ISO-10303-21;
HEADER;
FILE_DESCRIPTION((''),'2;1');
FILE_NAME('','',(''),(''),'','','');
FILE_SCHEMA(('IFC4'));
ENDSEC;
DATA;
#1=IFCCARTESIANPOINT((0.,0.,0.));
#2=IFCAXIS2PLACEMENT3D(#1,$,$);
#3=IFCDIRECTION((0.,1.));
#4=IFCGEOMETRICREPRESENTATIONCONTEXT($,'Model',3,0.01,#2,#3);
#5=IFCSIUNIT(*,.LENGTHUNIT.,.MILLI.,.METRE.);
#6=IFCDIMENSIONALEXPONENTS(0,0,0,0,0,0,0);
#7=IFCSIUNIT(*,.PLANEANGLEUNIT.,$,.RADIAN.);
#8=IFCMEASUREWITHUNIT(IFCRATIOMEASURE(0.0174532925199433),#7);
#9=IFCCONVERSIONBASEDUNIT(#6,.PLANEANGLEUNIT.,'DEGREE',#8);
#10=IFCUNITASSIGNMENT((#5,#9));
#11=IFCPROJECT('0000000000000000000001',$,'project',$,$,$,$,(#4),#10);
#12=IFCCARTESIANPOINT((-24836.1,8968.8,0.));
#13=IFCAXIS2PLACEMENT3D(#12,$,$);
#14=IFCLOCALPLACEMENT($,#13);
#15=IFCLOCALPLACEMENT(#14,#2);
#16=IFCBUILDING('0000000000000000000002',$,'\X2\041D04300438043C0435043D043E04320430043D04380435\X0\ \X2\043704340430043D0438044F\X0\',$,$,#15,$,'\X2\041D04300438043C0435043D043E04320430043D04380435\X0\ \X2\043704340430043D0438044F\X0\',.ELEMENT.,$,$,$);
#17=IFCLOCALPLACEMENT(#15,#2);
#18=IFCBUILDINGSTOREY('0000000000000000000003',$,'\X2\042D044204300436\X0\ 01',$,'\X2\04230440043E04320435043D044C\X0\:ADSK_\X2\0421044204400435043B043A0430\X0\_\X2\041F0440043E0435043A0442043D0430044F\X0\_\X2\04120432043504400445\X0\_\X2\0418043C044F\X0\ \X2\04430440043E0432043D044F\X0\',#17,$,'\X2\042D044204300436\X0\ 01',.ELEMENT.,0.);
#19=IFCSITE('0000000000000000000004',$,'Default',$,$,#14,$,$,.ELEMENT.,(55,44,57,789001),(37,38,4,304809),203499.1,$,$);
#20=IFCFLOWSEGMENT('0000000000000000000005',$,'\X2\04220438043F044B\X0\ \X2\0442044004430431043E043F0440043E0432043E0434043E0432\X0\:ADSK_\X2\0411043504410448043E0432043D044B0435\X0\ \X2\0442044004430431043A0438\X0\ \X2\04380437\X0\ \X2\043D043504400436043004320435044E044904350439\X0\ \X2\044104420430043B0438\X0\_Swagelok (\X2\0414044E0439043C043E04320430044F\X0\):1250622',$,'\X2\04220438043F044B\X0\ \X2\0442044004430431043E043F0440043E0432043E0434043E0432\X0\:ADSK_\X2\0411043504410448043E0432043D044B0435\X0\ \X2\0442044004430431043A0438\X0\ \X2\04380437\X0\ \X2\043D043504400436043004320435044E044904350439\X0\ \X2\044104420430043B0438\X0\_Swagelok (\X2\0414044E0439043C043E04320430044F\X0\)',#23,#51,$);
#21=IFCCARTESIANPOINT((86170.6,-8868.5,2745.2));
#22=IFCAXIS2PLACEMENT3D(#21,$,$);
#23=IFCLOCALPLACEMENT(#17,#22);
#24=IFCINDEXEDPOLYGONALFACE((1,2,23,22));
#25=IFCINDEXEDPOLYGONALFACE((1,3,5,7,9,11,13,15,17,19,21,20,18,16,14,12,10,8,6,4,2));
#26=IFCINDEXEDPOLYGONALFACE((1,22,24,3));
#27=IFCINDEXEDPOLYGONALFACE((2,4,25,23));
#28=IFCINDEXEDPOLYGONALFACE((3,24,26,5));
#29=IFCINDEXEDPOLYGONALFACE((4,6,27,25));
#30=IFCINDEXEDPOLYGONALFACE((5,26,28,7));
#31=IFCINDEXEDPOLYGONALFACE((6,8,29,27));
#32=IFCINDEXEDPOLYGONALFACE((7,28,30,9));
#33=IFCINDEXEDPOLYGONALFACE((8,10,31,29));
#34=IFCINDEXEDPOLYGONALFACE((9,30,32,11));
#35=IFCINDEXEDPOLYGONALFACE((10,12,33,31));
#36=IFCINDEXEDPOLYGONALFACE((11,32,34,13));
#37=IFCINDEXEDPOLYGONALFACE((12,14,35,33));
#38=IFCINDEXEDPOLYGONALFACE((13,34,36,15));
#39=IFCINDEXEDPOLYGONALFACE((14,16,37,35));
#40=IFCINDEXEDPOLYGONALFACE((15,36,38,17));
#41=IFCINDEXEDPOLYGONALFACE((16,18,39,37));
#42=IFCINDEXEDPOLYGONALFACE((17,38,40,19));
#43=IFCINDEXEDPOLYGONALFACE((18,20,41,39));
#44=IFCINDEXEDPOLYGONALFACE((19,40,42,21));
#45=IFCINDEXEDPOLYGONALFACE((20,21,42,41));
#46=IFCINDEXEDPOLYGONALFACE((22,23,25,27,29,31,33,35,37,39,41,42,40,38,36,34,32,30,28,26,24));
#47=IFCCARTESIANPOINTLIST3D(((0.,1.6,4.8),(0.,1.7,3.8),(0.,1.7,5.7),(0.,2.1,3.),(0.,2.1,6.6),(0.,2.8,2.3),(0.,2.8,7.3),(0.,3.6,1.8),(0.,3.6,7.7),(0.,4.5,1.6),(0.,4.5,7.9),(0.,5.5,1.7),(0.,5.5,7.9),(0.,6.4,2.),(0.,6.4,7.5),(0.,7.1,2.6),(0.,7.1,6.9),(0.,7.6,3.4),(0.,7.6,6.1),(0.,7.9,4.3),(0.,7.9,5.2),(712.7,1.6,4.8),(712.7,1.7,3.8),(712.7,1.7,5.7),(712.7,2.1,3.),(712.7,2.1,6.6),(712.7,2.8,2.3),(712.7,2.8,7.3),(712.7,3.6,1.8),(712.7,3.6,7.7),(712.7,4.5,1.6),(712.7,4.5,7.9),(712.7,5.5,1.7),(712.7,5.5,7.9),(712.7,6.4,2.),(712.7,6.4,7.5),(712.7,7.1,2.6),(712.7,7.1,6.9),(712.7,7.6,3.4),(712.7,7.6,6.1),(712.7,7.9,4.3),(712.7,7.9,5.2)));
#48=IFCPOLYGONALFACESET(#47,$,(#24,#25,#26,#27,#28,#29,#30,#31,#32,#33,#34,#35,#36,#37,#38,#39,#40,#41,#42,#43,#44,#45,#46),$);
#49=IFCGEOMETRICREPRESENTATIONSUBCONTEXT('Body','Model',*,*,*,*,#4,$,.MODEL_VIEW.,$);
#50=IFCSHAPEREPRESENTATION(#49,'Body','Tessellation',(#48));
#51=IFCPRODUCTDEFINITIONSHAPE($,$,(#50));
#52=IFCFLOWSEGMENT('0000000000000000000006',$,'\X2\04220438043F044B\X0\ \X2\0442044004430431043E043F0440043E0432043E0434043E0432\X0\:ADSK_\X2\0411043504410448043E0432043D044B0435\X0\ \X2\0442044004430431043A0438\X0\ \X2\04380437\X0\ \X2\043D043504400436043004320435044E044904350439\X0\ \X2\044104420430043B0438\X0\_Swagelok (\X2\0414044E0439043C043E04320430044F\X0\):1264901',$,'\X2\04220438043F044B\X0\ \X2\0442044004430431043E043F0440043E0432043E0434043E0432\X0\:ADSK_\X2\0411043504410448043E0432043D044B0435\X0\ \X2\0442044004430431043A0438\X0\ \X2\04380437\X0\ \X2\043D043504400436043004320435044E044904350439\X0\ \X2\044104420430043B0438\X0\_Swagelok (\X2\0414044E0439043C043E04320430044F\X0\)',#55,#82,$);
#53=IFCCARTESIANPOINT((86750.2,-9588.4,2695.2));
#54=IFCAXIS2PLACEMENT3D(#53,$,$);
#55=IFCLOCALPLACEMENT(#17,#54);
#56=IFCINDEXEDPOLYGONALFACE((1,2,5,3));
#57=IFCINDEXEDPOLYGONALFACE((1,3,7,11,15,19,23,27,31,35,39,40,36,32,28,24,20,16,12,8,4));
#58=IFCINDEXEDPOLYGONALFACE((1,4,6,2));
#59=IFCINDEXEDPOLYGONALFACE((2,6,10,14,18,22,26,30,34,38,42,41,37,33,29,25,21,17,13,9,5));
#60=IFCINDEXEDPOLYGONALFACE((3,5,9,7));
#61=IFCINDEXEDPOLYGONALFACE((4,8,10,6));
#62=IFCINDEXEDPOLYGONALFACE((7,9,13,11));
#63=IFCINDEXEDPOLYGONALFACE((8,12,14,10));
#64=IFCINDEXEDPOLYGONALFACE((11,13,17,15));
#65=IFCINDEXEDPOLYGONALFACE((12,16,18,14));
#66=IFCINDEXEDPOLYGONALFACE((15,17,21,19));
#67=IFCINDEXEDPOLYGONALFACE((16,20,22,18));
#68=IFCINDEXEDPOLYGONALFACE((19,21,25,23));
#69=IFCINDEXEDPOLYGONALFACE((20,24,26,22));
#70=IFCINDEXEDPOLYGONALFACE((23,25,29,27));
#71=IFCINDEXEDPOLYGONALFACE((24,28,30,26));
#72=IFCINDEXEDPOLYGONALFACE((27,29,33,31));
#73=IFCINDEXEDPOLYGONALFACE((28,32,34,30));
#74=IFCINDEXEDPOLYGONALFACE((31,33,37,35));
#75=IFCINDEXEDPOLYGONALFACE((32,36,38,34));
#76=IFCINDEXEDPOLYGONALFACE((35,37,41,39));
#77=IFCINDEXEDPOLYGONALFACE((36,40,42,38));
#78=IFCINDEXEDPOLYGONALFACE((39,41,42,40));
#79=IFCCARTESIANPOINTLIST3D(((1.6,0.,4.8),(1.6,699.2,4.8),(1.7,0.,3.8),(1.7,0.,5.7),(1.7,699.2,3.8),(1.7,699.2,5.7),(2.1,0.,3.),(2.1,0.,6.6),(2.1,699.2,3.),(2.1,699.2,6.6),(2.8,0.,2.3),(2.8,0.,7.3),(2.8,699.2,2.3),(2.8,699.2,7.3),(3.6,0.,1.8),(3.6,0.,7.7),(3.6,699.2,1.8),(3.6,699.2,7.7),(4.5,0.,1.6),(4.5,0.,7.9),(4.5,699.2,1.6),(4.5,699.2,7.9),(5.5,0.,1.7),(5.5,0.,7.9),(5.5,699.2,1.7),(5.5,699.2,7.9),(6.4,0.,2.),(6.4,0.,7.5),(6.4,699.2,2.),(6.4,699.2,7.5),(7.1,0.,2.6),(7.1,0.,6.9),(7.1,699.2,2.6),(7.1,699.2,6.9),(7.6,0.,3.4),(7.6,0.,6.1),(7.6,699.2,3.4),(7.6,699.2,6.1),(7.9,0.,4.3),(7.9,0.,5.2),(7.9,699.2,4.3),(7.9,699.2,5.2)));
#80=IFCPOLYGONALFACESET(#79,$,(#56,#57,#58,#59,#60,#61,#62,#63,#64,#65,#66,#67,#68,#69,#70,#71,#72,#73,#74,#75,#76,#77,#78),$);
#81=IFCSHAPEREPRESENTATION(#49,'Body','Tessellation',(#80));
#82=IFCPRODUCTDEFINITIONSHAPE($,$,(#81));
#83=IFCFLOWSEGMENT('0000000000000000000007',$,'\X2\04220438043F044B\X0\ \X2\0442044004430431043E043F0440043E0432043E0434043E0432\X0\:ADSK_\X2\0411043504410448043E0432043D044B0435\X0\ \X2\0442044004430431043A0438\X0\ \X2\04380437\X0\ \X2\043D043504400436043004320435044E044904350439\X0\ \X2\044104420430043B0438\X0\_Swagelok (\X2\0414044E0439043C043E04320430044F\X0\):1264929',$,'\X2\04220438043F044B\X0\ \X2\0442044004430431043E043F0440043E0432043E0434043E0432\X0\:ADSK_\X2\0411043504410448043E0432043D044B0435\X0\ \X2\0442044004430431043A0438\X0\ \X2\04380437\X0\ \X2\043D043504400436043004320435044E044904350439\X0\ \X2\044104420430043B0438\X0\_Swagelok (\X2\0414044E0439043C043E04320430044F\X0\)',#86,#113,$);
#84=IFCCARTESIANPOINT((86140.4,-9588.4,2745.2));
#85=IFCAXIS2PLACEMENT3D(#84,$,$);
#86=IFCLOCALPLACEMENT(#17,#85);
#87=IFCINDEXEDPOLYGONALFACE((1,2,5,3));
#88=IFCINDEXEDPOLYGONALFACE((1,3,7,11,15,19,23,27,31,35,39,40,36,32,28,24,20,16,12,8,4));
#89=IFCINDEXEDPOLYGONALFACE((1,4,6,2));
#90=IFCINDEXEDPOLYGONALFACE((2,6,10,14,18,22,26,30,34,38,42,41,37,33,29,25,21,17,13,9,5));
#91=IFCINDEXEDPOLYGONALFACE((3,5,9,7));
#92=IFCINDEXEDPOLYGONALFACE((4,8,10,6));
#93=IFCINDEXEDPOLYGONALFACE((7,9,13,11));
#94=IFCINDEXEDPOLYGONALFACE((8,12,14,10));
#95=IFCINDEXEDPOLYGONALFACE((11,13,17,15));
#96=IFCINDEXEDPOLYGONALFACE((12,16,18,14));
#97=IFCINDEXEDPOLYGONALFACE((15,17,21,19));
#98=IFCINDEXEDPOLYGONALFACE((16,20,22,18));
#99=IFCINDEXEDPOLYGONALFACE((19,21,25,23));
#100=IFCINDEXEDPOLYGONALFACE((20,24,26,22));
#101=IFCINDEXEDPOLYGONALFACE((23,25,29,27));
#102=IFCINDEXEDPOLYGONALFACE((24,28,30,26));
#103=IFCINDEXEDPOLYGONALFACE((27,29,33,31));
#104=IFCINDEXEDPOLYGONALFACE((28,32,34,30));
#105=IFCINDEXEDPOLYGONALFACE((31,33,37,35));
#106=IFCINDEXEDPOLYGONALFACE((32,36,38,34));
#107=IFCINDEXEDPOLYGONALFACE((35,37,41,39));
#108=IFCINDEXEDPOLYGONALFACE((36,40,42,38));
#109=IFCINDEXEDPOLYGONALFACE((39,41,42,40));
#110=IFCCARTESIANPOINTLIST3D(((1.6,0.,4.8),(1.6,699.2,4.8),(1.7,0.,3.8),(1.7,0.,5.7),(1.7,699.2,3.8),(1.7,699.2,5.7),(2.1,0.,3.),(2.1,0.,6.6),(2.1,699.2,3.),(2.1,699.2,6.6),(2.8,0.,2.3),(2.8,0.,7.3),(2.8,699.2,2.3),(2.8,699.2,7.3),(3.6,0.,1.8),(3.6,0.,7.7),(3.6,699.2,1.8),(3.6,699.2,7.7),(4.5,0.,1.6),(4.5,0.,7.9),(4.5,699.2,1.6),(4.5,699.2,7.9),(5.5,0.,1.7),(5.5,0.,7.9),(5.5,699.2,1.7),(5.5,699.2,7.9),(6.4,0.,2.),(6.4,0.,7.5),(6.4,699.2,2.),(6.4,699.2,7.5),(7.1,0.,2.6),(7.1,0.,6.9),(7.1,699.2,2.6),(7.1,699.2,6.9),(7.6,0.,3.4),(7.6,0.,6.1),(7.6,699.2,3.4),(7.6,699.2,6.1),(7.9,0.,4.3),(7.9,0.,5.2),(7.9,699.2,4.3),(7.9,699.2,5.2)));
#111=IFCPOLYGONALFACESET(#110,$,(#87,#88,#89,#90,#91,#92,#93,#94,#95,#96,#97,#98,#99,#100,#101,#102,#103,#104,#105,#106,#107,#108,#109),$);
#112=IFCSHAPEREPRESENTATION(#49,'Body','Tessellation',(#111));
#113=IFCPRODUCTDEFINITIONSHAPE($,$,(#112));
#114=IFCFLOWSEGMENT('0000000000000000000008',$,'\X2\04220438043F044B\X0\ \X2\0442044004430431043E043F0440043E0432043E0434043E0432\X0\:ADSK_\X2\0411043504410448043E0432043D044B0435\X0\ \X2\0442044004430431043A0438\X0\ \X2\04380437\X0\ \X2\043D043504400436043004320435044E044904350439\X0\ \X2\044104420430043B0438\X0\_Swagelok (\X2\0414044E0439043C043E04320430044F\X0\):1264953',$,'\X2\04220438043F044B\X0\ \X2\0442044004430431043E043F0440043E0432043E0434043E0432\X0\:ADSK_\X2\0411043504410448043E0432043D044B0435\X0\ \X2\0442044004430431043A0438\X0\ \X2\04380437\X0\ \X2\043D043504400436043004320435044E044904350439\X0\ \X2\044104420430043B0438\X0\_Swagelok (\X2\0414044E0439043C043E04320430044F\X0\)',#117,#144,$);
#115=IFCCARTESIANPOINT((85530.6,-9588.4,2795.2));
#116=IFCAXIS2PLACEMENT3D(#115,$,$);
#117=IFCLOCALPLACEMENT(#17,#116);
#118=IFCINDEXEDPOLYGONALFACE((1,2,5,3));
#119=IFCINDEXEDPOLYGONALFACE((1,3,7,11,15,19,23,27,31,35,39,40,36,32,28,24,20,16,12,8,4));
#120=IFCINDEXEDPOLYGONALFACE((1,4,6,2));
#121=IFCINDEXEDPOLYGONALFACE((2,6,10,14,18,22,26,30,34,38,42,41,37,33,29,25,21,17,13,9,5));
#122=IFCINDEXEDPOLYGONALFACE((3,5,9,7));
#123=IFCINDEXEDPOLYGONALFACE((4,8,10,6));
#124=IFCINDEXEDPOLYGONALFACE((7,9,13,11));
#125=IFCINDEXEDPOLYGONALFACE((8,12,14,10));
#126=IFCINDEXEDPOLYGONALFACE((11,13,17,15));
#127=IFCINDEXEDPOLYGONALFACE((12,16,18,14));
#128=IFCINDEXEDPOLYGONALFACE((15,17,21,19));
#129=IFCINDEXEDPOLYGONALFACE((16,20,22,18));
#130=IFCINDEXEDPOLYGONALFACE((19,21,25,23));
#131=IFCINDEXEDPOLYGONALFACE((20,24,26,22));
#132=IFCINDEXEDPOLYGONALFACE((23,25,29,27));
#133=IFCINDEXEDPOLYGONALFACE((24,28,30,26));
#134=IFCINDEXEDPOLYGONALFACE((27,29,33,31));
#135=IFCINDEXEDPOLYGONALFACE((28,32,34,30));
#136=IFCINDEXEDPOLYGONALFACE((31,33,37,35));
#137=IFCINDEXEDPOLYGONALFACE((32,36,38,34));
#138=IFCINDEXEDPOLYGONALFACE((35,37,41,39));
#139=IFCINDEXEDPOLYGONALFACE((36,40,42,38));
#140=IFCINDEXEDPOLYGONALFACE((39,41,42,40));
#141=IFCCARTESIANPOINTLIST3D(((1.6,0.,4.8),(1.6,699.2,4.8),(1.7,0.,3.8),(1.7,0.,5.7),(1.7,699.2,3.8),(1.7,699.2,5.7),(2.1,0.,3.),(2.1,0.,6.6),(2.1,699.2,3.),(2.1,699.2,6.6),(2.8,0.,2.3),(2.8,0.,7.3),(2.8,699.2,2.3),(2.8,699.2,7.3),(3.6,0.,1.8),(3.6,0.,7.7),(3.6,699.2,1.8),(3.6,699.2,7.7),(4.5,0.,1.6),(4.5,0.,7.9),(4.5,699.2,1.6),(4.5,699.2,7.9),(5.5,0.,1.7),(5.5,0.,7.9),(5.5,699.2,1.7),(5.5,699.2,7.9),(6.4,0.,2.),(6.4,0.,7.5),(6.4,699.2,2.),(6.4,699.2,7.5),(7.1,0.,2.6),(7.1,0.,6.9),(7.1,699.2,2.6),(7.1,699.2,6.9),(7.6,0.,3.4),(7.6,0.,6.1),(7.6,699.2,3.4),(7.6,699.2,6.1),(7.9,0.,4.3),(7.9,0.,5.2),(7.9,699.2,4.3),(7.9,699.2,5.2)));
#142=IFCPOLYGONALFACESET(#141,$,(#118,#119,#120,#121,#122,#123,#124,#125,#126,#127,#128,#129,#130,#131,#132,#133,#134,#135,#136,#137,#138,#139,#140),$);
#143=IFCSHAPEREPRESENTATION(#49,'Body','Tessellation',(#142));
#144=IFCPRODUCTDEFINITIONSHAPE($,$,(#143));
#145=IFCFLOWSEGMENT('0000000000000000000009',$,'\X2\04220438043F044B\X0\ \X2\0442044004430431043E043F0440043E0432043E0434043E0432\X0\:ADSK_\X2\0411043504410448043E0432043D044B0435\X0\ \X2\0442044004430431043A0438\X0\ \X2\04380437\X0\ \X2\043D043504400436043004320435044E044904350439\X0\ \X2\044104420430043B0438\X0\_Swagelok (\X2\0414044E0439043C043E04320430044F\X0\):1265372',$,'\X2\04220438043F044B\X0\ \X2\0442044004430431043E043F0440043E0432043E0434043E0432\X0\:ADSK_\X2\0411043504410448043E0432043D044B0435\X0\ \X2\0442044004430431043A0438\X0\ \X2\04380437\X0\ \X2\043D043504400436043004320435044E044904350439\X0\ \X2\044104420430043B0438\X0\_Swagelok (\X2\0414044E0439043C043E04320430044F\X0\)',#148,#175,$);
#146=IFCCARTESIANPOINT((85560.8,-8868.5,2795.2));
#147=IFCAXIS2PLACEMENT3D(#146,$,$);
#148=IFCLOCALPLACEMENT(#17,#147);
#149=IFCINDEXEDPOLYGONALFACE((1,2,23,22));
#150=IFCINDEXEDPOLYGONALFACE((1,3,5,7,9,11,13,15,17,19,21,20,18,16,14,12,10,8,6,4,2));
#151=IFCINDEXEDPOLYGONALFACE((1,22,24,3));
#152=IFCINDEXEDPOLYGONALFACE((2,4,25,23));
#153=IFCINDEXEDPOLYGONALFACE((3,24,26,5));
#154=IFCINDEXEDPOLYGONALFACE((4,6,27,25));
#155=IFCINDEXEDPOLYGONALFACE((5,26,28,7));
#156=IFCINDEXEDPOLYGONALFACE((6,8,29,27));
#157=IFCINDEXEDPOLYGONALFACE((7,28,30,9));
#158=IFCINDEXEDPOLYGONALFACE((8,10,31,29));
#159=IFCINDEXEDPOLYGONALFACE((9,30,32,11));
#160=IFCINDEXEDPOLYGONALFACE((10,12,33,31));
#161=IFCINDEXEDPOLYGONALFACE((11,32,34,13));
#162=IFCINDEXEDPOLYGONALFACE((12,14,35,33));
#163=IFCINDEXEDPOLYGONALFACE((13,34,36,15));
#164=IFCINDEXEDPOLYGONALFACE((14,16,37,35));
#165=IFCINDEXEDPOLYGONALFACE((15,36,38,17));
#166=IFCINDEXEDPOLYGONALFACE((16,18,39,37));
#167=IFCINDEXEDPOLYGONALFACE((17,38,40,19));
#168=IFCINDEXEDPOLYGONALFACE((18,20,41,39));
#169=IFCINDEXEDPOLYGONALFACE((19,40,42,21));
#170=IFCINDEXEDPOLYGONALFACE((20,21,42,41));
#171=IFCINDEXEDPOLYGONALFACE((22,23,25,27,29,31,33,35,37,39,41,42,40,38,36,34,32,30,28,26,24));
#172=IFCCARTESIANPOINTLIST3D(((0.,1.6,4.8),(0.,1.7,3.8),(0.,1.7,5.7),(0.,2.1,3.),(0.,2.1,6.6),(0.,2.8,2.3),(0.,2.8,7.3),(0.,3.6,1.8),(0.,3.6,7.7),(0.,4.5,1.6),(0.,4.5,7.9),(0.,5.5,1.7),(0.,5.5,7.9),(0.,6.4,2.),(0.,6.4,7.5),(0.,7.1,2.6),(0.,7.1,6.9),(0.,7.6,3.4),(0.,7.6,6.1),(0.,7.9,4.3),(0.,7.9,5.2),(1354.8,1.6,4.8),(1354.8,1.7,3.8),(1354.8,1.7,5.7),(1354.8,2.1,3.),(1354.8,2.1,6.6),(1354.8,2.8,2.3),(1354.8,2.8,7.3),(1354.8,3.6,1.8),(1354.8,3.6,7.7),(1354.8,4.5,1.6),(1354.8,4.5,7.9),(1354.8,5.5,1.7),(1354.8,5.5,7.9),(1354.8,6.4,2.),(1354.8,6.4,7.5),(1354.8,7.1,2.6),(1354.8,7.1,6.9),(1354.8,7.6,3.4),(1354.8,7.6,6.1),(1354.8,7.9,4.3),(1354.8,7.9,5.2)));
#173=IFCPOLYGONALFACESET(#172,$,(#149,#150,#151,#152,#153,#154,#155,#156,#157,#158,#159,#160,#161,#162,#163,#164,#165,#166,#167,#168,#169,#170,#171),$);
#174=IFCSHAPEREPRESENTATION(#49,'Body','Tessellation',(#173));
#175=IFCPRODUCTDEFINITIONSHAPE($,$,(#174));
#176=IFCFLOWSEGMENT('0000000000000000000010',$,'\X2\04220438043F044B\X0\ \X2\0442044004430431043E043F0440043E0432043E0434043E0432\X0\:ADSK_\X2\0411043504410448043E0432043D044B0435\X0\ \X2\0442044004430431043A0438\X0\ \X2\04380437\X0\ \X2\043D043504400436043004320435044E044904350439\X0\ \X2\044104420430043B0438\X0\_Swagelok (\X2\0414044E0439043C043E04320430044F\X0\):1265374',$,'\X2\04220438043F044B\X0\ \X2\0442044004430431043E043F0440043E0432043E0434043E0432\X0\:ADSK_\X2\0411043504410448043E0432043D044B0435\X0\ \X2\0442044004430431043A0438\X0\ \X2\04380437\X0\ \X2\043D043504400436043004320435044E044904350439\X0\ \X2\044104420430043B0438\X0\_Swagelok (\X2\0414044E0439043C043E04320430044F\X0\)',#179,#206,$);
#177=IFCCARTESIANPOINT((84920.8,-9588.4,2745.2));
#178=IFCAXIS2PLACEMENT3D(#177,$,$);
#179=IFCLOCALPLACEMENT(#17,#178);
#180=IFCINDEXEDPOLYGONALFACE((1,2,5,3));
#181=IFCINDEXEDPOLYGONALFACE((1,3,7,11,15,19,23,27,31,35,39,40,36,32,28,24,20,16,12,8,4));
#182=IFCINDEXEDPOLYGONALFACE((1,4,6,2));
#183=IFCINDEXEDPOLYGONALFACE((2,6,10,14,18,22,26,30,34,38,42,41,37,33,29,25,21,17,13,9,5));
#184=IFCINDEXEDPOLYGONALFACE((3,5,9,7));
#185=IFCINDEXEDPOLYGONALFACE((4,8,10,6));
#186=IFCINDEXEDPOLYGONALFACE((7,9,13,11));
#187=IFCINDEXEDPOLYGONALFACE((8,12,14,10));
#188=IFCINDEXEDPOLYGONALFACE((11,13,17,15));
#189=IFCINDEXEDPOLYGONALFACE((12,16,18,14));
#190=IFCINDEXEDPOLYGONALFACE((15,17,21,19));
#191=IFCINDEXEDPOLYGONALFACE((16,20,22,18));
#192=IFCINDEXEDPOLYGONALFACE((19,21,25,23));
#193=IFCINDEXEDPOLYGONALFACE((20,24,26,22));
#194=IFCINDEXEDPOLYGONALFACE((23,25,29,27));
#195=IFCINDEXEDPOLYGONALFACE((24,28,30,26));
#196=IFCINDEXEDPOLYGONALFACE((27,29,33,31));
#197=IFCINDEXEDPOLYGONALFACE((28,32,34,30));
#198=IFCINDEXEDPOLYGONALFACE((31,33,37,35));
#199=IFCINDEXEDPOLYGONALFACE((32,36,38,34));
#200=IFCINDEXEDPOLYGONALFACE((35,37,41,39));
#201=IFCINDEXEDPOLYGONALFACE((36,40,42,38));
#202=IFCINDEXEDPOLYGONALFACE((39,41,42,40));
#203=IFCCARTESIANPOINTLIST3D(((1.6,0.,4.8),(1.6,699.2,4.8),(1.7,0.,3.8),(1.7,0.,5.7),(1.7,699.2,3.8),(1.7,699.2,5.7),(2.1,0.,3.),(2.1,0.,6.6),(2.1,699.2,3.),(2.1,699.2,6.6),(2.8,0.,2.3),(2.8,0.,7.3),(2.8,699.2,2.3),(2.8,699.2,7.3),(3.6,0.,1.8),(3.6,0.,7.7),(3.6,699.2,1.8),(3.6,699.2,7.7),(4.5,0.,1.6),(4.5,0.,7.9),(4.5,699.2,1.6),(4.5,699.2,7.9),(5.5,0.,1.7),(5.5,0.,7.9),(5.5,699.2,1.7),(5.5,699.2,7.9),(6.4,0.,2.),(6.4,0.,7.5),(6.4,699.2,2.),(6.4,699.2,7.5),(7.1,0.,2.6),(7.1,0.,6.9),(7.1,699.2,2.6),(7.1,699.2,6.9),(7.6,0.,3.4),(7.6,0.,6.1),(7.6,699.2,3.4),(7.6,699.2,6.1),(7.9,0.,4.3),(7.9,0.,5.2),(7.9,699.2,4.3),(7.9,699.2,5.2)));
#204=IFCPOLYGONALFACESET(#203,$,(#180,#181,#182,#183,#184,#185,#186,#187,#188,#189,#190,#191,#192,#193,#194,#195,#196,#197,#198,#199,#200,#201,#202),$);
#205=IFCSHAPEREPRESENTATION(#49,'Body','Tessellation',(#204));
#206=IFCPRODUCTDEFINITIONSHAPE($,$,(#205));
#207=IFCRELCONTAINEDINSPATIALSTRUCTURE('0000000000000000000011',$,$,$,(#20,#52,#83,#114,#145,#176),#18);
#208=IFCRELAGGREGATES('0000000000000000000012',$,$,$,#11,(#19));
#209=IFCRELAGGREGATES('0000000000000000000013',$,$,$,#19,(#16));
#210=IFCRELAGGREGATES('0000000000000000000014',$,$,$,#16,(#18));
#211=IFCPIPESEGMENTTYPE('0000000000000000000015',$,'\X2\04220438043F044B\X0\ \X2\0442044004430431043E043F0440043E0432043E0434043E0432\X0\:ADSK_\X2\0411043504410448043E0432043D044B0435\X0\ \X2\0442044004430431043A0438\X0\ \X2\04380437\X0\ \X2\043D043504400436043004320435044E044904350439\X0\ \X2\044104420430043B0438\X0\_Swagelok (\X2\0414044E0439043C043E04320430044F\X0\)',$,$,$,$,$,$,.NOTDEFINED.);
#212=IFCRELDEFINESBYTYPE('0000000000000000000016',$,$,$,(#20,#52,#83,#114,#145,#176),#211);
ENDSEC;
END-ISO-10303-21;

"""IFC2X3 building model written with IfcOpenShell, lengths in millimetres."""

from ifc_helpers import new_model, entity, si_unit, converted_unit, direction, frame, origin, origin_2d_with_axis, place, context, subcontext, project, spatial, circle, extrude, type_object, element, save


model = new_model("IFC2X3")

# Units and contexts
model_context = context("Model", 3, precision=0.01, world=origin(), true_north=direction((0.0, 1.0)))
body_context = subcontext(model_context, "Body", "Model", "MODEL_VIEW")
ifc_project = project(units=[si_unit("LENGTHUNIT", "METRE", prefix="MILLI"), converted_unit("PLANEANGLEUNIT", "DEGREE", entity("IfcRatioMeasure", 0.0174532925199433), si_unit("PLANEANGLEUNIT", "RADIAN"), dimensions=[0, 0, 0, 0, 0, 0, 0])], contexts=[model_context])

# Site, building, storey
site_placement = place(None, frame((-24836.1, 8968.8, 0.0)))
site = spatial("IfcSite", under=ifc_project, at=site_placement, Name="Default", CompositionType="ELEMENT", RefLatitude=(55, 44, 57, 789001), RefLongitude=(37, 38, 4, 304809), RefElevation=203499.1)
building_placement = place(site_placement, origin())
building = spatial("IfcBuilding", under=site, at=building_placement, Name="Наименование здания", LongName="Наименование здания", CompositionType="ELEMENT")
storey_placement = place(building_placement, origin())
storey = spatial("IfcBuildingStorey", under=building, at=storey_placement, Name="Этаж 01", ObjectType="Уровень:ADSK_Стрелка_Проектная_Вверх_Имя уровня", LongName="Этаж 01", CompositionType="ELEMENT", Elevation=0.0)

# Flow segments
pipe_segment_type_1 = type_object("IfcPipeSegmentType", Name="Типы трубопроводов:ADSK_Бесшовные трубки из нержавеющей стали_Swagelok (Дюймовая)", PredefinedType="NOTDEFINED")
flow_segment_1_placement = place(storey_placement, frame((86170.6, -8868.5, 2745.2)))
element("IfcFlowSegment", 1, at=flow_segment_1_placement, inside=storey, type_object=pipe_segment_type_1, Name="Типы трубопроводов:ADSK_Бесшовные трубки из нержавеющей стали_Swagelok (Дюймовая):1250622", ObjectType="Типы трубопроводов:ADSK_Бесшовные трубки из нержавеющей стали_Swagelok (Дюймовая)", context=body_context, shape_type="SweptSolid", body=[
    extrude(circle(Radius=3.2, at=origin_2d_with_axis()), frame((0.0, 4.8, 4.8), z_axis=(1.0, 0.0, 0.0), x_axis=(0.0, -1.0, 0.0)), (0.0, 0.0, 1.0), 712.7),
])
flow_segment_2_placement = place(storey_placement, frame((86750.2, -9588.4, 2695.2)))
element("IfcFlowSegment", 2, at=flow_segment_2_placement, inside=storey, type_object=pipe_segment_type_1, Name="Типы трубопроводов:ADSK_Бесшовные трубки из нержавеющей стали_Swagelok (Дюймовая):1264901", ObjectType="Типы трубопроводов:ADSK_Бесшовные трубки из нержавеющей стали_Swagelok (Дюймовая)", context=body_context, shape_type="SweptSolid", body=[
    extrude(circle(Radius=3.2, at=origin_2d_with_axis()), frame((4.8, 0.0, 4.8), z_axis=(0.0, 1.0, 0.0), x_axis=(-1.0, 0.0, 0.0)), (0.0, 0.0, 1.0), 699.2),
])
flow_segment_3_placement = place(storey_placement, frame((86140.4, -9588.4, 2745.2)))
element("IfcFlowSegment", 3, at=flow_segment_3_placement, inside=storey, type_object=pipe_segment_type_1, Name="Типы трубопроводов:ADSK_Бесшовные трубки из нержавеющей стали_Swagelok (Дюймовая):1264929", ObjectType="Типы трубопроводов:ADSK_Бесшовные трубки из нержавеющей стали_Swagelok (Дюймовая)", context=body_context, shape_type="SweptSolid", body=[
    extrude(circle(Radius=3.2, at=origin_2d_with_axis()), frame((4.8, 0.0, 4.8), z_axis=(0.0, 1.0, 0.0), x_axis=(-1.0, 0.0, 0.0)), (0.0, 0.0, 1.0), 699.2),
])
flow_segment_4_placement = place(storey_placement, frame((85530.6, -9588.4, 2795.2)))
element("IfcFlowSegment", 4, at=flow_segment_4_placement, inside=storey, type_object=pipe_segment_type_1, Name="Типы трубопроводов:ADSK_Бесшовные трубки из нержавеющей стали_Swagelok (Дюймовая):1264953", ObjectType="Типы трубопроводов:ADSK_Бесшовные трубки из нержавеющей стали_Swagelok (Дюймовая)", context=body_context, shape_type="SweptSolid", body=[
    extrude(circle(Radius=3.2, at=origin_2d_with_axis()), frame((4.8, 0.0, 4.8), z_axis=(0.0, 1.0, 0.0), x_axis=(-1.0, 0.0, 0.0)), (0.0, 0.0, 1.0), 699.2),
])
flow_segment_5_placement = place(storey_placement, frame((85560.8, -8868.5, 2795.2)))
element("IfcFlowSegment", 5, at=flow_segment_5_placement, inside=storey, type_object=pipe_segment_type_1, Name="Типы трубопроводов:ADSK_Бесшовные трубки из нержавеющей стали_Swagelok (Дюймовая):1265372", ObjectType="Типы трубопроводов:ADSK_Бесшовные трубки из нержавеющей стали_Swagelok (Дюймовая)", context=body_context, shape_type="SweptSolid", body=[
    extrude(circle(Radius=3.2, at=origin_2d_with_axis()), frame((0.0, 4.8, 4.8), z_axis=(1.0, 0.0, 0.0), x_axis=(0.0, -1.0, 0.0)), (0.0, 0.0, 1.0), 1354.8),
])
flow_segment_6_placement = place(storey_placement, frame((84920.8, -9588.4, 2745.2)))
element("IfcFlowSegment", 6, at=flow_segment_6_placement, inside=storey, type_object=pipe_segment_type_1, Name="Типы трубопроводов:ADSK_Бесшовные трубки из нержавеющей стали_Swagelok (Дюймовая):1265374", ObjectType="Типы трубопроводов:ADSK_Бесшовные трубки из нержавеющей стали_Swagelok (Дюймовая)", context=body_context, shape_type="SweptSolid", body=[
    extrude(circle(Radius=3.2, at=origin_2d_with_axis()), frame((4.8, 0.0, 4.8), z_axis=(0.0, 1.0, 0.0), x_axis=(-1.0, 0.0, 0.0)), (0.0, 0.0, 1.0), 699.2),
])

save(model, "model.ifc")
